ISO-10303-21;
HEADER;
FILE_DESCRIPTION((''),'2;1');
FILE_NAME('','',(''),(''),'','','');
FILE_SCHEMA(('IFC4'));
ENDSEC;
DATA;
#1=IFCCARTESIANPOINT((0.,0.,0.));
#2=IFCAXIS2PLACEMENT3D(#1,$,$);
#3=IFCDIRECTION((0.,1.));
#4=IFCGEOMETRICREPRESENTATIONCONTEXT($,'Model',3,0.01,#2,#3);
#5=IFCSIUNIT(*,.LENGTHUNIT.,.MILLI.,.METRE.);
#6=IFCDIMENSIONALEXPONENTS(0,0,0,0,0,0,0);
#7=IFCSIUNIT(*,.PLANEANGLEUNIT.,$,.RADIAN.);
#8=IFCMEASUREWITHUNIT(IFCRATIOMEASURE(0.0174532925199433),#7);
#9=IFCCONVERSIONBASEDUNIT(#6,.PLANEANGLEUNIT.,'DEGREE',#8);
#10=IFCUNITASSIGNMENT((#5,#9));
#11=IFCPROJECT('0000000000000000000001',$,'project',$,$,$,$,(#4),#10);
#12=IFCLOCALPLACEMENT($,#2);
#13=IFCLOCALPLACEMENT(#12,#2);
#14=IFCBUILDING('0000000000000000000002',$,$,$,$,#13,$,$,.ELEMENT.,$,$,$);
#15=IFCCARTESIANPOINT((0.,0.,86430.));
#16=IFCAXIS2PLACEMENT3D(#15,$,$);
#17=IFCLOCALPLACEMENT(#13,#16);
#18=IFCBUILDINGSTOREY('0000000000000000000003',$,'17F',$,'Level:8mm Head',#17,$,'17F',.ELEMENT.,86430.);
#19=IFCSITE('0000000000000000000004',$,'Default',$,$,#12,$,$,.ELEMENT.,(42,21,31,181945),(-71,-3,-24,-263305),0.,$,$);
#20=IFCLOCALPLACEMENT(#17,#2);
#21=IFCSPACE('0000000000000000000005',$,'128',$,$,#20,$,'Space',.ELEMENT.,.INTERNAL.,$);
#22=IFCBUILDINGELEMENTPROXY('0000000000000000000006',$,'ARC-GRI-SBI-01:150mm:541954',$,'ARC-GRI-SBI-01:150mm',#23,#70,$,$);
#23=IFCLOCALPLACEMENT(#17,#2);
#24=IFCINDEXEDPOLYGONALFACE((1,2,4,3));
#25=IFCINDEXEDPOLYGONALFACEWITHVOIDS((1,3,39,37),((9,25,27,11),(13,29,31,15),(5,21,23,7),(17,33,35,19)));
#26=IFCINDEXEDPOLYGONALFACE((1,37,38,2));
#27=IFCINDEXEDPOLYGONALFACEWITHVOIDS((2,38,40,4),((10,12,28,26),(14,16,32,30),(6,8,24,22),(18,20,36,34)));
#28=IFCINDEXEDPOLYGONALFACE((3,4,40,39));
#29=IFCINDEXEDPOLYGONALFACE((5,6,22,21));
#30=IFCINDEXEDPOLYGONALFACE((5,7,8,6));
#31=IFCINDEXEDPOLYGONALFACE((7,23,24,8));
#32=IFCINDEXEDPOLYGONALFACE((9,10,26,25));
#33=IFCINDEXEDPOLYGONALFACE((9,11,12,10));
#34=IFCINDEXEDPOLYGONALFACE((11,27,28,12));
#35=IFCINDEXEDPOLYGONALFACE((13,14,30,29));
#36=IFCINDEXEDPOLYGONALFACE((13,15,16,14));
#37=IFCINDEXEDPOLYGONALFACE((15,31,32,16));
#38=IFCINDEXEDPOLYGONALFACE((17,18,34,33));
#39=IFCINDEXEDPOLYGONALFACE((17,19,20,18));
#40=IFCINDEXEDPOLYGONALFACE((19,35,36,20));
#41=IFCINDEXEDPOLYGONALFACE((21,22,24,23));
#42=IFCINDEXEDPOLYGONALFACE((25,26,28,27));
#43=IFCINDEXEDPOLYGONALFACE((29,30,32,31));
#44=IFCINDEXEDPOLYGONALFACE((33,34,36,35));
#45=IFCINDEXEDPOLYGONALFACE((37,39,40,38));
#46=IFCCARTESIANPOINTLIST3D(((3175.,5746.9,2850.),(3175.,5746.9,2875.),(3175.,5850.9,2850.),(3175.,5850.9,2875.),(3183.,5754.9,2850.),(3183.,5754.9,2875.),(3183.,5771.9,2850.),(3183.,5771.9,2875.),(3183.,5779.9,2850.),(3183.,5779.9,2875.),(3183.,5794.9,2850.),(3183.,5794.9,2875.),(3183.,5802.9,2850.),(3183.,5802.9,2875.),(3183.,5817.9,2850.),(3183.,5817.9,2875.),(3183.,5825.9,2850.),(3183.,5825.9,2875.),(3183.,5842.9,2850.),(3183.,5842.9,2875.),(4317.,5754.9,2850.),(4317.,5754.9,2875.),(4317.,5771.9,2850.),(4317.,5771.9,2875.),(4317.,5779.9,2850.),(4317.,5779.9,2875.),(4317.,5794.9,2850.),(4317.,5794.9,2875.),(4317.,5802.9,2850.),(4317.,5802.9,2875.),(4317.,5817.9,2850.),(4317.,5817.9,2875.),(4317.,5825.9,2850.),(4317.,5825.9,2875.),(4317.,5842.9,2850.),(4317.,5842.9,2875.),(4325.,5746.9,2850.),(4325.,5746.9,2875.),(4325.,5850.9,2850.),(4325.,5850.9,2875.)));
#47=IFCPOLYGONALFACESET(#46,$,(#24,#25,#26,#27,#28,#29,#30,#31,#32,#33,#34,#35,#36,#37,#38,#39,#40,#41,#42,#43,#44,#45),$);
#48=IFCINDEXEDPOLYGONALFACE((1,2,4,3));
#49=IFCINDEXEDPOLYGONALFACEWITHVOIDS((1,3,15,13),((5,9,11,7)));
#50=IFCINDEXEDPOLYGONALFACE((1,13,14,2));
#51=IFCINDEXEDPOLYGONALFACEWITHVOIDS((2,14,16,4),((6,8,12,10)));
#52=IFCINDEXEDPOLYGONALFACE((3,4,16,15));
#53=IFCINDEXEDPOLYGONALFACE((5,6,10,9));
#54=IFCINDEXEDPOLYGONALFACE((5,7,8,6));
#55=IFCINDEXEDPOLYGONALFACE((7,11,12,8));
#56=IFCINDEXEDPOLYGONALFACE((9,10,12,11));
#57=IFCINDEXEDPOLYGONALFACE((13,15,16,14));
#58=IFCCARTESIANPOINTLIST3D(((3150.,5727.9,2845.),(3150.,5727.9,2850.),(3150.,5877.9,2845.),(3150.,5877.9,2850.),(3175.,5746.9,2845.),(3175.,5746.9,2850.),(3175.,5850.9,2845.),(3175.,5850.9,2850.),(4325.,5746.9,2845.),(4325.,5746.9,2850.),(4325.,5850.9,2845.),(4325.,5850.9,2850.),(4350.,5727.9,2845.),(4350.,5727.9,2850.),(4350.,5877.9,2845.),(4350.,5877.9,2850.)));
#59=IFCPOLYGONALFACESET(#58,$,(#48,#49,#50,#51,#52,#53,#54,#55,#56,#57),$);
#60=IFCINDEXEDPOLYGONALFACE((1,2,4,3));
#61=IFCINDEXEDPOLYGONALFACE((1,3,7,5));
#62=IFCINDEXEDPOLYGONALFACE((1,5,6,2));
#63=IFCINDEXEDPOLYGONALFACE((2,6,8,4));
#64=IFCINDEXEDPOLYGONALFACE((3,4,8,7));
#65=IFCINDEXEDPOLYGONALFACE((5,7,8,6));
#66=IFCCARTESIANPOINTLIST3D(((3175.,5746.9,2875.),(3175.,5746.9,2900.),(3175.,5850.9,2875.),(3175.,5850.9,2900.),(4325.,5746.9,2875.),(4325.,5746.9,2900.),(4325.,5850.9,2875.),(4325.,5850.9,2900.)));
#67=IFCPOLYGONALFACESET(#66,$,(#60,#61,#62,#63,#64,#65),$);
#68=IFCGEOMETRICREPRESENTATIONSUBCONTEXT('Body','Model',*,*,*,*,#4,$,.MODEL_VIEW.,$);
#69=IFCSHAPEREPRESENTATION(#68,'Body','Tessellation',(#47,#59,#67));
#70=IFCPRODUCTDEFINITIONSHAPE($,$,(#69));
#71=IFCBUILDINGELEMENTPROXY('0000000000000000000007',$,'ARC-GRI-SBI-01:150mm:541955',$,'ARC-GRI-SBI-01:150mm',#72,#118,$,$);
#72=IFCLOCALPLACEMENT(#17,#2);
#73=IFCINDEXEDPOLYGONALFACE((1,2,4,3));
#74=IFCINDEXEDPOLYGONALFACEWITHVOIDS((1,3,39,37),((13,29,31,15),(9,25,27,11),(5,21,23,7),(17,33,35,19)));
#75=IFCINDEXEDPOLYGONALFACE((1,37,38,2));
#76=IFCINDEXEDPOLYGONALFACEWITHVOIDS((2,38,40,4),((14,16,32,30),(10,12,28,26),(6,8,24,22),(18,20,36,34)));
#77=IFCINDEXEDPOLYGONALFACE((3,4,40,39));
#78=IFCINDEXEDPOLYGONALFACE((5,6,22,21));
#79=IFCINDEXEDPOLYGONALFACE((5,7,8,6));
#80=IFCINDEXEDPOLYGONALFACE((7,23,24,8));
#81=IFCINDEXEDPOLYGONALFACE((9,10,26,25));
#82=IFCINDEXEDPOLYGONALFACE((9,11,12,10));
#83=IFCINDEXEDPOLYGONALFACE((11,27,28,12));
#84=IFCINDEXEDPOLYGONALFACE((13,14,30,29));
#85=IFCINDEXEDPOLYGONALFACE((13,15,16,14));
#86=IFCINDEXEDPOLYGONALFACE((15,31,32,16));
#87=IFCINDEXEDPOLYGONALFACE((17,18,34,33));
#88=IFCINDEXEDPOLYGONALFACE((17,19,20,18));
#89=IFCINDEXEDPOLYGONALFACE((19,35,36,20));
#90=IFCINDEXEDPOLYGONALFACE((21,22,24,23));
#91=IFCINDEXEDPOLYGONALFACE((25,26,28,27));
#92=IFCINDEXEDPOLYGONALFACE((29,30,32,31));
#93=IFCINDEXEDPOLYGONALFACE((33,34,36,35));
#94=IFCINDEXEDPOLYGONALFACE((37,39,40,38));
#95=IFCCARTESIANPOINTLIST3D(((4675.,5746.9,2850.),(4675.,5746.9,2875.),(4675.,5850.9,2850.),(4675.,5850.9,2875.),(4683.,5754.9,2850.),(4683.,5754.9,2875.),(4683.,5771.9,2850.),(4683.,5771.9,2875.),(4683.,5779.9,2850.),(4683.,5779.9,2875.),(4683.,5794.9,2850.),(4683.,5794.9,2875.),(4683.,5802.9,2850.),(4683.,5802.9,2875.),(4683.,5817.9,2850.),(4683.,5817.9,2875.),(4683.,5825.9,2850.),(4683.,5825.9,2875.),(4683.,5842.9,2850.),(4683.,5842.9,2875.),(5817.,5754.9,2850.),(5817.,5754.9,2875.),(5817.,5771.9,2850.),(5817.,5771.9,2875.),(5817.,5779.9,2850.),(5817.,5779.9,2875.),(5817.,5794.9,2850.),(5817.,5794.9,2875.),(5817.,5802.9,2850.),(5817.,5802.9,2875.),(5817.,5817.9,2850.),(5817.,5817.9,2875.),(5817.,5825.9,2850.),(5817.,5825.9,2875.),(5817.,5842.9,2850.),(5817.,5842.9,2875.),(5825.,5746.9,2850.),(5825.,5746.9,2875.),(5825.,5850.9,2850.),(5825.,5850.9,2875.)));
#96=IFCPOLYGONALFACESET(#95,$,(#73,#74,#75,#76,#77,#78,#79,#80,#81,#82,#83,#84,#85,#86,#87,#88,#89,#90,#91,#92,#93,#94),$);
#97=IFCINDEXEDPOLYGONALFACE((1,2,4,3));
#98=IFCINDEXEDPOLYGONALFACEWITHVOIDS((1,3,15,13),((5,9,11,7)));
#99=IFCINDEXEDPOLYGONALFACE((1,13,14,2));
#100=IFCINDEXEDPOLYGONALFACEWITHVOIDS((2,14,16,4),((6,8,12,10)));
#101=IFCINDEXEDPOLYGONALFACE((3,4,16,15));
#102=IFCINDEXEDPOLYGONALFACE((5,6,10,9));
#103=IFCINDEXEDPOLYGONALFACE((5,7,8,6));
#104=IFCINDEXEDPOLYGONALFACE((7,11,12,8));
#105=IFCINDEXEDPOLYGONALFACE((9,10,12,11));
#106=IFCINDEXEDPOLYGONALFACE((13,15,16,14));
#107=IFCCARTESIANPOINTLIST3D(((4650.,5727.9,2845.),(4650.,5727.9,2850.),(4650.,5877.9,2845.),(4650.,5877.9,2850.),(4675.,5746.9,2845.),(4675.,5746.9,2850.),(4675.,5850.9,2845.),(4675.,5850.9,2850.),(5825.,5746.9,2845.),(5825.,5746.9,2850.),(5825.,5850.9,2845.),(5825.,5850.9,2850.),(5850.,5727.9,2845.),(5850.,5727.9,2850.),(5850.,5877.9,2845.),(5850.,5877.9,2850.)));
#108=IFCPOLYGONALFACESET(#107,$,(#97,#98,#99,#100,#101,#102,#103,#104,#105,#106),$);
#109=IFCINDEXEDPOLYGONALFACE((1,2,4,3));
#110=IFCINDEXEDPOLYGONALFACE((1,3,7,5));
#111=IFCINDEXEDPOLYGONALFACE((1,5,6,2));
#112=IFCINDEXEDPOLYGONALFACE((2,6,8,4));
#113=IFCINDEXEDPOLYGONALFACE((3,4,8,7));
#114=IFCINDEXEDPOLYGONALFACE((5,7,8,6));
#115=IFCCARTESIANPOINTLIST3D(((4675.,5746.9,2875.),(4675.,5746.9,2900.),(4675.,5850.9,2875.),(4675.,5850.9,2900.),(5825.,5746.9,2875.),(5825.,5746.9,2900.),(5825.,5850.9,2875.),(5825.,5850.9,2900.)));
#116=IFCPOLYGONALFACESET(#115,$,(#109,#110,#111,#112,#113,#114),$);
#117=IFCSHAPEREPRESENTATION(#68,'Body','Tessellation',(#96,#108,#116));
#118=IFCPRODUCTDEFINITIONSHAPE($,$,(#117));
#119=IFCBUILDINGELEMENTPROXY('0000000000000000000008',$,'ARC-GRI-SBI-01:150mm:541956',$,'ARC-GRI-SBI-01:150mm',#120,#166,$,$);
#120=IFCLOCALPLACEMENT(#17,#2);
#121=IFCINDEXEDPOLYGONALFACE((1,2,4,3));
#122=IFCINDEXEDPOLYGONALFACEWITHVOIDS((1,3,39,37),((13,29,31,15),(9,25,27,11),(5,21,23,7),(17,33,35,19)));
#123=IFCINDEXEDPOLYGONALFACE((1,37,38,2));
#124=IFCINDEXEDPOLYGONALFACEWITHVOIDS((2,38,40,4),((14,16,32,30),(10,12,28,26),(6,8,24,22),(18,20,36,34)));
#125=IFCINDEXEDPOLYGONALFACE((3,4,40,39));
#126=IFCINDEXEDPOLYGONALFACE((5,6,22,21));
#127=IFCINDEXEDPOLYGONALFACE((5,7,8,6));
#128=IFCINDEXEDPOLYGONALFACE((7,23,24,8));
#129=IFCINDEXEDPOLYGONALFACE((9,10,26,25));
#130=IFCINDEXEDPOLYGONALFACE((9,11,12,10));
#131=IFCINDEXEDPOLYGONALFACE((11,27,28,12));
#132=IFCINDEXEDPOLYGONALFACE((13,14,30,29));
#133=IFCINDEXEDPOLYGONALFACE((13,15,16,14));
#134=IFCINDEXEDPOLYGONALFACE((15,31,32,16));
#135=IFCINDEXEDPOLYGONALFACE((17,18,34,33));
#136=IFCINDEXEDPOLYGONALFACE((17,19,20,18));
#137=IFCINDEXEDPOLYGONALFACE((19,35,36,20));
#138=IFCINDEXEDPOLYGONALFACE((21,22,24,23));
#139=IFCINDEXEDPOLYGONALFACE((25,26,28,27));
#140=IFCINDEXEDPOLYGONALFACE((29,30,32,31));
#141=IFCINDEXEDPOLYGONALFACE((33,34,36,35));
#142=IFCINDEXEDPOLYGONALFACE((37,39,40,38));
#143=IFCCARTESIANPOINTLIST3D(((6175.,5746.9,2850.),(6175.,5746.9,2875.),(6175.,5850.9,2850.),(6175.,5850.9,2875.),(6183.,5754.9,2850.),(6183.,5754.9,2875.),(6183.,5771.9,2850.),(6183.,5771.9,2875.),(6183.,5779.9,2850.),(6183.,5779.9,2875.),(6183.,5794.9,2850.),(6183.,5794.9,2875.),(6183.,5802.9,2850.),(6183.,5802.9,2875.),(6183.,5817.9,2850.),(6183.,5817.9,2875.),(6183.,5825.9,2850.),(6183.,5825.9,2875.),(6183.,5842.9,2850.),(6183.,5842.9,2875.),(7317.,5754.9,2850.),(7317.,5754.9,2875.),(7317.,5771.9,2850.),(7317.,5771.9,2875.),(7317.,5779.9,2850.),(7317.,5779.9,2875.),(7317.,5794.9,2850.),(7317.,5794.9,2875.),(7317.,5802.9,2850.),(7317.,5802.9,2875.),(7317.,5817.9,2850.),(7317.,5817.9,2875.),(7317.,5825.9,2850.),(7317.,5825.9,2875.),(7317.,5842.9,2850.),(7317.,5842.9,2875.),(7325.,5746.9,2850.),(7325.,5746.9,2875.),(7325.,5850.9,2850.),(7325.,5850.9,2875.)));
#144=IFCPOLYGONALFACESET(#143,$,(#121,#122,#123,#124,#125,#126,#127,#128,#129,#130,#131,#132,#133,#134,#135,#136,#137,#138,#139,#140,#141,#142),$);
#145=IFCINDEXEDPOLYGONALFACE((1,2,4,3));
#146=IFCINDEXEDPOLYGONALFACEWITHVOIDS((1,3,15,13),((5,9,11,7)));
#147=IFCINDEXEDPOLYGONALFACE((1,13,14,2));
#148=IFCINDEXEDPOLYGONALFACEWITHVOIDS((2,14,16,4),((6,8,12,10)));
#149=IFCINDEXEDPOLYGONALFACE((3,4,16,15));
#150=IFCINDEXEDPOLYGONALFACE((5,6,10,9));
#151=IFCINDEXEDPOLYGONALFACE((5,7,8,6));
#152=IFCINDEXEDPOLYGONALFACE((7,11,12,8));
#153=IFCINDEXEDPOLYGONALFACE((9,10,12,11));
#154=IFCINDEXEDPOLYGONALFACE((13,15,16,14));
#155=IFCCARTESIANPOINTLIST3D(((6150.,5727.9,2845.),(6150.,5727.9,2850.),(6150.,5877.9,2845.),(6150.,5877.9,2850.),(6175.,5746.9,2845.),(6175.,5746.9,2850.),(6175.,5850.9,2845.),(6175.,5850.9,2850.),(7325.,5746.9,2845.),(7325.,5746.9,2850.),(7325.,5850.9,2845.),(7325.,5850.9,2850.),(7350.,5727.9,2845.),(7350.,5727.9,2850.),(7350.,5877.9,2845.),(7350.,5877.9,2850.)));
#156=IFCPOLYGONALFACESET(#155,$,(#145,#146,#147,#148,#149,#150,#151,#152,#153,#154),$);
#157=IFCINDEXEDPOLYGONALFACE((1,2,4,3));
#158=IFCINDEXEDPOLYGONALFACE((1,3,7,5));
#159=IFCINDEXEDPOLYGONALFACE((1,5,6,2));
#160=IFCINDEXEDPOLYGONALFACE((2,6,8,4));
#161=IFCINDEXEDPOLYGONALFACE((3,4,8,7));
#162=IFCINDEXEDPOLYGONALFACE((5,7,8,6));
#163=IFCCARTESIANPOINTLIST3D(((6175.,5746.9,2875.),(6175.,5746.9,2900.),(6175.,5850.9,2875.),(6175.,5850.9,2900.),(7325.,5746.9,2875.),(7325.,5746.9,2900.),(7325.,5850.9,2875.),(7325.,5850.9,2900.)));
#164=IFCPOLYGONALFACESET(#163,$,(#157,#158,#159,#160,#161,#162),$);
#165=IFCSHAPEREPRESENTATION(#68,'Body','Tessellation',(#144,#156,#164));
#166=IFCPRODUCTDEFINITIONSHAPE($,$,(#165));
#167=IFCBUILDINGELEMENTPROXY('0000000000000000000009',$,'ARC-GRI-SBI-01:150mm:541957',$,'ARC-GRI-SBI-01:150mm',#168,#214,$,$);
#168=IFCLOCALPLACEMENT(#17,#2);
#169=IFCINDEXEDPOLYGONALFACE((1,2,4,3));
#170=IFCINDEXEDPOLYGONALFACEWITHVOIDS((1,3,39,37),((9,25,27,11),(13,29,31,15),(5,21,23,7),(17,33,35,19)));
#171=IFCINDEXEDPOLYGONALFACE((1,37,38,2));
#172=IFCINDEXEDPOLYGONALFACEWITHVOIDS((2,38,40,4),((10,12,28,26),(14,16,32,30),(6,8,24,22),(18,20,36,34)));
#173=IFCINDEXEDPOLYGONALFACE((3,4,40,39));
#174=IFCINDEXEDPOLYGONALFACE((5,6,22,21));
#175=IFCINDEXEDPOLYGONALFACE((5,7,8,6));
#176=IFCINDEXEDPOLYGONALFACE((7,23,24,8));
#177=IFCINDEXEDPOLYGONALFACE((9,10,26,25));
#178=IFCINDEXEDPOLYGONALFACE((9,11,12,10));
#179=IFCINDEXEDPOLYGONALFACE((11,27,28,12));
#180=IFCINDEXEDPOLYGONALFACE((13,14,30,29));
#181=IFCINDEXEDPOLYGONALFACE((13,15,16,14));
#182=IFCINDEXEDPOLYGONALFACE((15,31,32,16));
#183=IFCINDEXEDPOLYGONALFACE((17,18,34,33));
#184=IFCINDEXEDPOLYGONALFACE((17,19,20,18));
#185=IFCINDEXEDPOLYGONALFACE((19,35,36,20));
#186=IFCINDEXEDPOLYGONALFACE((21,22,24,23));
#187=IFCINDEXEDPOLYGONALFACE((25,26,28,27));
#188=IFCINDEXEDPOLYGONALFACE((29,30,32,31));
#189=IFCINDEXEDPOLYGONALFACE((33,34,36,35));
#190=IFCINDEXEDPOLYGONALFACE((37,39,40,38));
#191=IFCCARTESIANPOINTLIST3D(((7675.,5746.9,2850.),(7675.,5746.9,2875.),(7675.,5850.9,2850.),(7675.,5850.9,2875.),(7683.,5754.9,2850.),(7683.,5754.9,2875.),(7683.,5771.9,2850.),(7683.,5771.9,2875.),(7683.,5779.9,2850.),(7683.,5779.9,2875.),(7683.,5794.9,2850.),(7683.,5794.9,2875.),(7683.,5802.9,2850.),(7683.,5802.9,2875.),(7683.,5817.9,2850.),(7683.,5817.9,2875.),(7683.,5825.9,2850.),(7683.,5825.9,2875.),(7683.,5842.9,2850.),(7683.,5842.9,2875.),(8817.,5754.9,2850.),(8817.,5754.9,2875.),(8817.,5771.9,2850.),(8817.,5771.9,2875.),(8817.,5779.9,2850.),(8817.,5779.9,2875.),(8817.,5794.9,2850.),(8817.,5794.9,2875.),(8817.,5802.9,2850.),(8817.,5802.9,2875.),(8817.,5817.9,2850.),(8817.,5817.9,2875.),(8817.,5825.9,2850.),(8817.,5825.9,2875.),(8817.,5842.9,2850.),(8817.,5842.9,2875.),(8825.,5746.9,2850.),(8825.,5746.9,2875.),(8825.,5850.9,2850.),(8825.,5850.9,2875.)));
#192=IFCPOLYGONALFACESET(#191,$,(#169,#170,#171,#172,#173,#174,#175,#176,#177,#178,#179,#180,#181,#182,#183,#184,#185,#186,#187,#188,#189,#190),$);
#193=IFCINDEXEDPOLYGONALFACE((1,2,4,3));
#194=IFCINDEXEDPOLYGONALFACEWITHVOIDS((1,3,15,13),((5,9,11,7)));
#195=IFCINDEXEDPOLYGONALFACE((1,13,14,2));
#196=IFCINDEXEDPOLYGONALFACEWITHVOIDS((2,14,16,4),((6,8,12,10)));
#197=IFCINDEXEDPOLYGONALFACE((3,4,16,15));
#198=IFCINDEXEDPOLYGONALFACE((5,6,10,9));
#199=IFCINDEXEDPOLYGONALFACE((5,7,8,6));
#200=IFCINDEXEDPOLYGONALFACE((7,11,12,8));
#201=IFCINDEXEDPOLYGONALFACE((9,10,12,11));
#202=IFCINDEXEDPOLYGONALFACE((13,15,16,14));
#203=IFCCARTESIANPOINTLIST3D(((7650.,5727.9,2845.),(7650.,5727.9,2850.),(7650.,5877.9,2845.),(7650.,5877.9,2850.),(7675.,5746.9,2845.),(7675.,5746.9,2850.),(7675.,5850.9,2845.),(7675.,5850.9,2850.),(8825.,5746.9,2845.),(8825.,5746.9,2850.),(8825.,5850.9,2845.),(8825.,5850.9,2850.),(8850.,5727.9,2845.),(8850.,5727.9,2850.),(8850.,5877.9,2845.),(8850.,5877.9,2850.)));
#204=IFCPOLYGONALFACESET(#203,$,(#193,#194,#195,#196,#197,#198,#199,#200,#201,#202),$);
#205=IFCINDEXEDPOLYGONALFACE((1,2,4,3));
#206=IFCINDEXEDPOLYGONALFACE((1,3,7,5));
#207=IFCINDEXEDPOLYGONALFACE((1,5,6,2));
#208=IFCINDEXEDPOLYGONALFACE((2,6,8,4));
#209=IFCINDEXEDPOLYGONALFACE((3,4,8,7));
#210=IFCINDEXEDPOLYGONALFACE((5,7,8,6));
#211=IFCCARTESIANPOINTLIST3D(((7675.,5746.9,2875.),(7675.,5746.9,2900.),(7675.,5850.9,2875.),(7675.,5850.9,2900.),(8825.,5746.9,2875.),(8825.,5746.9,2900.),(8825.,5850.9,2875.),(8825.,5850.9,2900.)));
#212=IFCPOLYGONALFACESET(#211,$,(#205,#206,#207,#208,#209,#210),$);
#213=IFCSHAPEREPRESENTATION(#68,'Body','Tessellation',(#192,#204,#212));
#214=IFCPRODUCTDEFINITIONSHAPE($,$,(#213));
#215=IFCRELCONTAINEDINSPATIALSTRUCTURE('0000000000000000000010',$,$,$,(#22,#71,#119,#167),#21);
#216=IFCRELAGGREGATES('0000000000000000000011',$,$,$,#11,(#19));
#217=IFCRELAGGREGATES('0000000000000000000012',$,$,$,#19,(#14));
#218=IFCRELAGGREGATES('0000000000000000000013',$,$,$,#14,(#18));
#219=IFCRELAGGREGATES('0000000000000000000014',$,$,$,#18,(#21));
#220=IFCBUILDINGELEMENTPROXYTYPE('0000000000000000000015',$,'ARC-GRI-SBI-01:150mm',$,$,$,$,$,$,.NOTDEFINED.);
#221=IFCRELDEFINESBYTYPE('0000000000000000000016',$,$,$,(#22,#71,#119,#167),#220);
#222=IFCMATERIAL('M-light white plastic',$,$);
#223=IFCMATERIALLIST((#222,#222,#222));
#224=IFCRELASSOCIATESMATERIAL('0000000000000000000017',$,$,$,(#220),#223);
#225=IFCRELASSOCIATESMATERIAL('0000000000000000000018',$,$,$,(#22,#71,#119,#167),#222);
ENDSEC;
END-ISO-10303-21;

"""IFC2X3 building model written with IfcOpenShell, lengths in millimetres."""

from ifc_helpers import new_model, entity, si_unit, converted_unit, direction, frame, origin, origin_2d_with_axis, place, context, subcontext, project, spatial, polyline, rectangle, outline, extrude, source, transform, mapped, material, material_list, type_object, type_shapes, element, save


model = new_model("IFC2X3")

# Units and contexts
model_context = context("Model", 3, precision=0.01, world=origin(), true_north=direction((0.0, 1.0)))
body_context = subcontext(model_context, "Body", "Model", "MODEL_VIEW")
ifc_project = project(units=[si_unit("LENGTHUNIT", "METRE", prefix="MILLI"), converted_unit("PLANEANGLEUNIT", "DEGREE", entity("IfcRatioMeasure", 0.0174532925199433), si_unit("PLANEANGLEUNIT", "RADIAN"), dimensions=[0, 0, 0, 0, 0, 0, 0])], contexts=[model_context])

# Site, building, storey
site_placement = place(None, origin())
site = spatial("IfcSite", under=ifc_project, at=site_placement, Name="Default", CompositionType="ELEMENT", RefLatitude=(42, 21, 31, 181945), RefLongitude=(-71, -3, -24, -263305), RefElevation=0.0)
building_placement = place(site_placement, origin())
building = spatial("IfcBuilding", under=site, at=building_placement, CompositionType="ELEMENT")
storey_placement = place(building_placement, frame((0.0, 0.0, 86430.0)))
storey = spatial("IfcBuildingStorey", under=building, at=storey_placement, Name="17F", ObjectType="Level:8mm Head", LongName="17F", CompositionType="ELEMENT", Elevation=86430.0)

# Shared definitions
space_placement = place(storey_placement, origin())
space = spatial("IfcSpace", under=storey, at=space_placement, Name="128", LongName="Space", CompositionType="ELEMENT", InteriorOrExteriorSpace="INTERNAL")

# Building element proxies
ifc_material_1 = material(Name="M-light white plastic")
ifc_material_list = material_list([ifc_material_1, ifc_material_1, ifc_material_1])
building_element_proxy_type = type_object("IfcBuildingElementProxyType", Name="ARC-GRI-SBI-01:150mm", PredefinedType="NOTDEFINED", material=ifc_material_list)
shared_shape = source(origin(), body_context, "Body", "SweptSolid", [
    extrude(outline(polyline([(-575.0, -52.0), (575.0, -52.0), (575.0, 52.0), (-575.0, 52.0), (-575.0, -52.0)]), holes=[polyline([(-567.0, -44.0), (-567.0, -27.0), (567.0, -27.0), (567.0, -44.0), (-567.0, -44.0)]), polyline([(567.0, -4.0), (567.0, -19.0), (-567.0, -19.0), (-567.0, -4.0), (567.0, -4.0)]), polyline([(-567.0, 44.0), (567.0, 44.0), (567.0, 27.0), (-567.0, 27.0), (-567.0, 44.0)]), polyline([(567.0, 4.0), (-567.0, 4.0), (-567.0, 19.0), (567.0, 19.0), (567.0, 4.0)])]), frame((425.0, 4.0, 4000.0), z_axis=(0.0, 0.0, 1.0), x_axis=(-1.0, 0.0, 0.0)), (0.0, 0.0, 1.0), 25.0),
    extrude(outline(polyline([(-600.0, -75.0), (600.0, -75.0), (600.0, 75.0), (-600.0, 75.0), (-600.0, -75.0)]), holes=[polyline([(-575.0, -56.0), (-575.0, 48.0), (575.0, 48.0), (575.0, -56.0), (-575.0, -56.0)])]), frame((425.0, 0.0, 3995.0), z_axis=(0.0, 0.0, 1.0), x_axis=(-1.0, 0.0, 0.0)), (0.0, 0.0, 1.0), 5.0),
    extrude(rectangle(XDim=1150.0, YDim=104.0, at=origin_2d_with_axis()), frame((425.0, 4.0, 4025.0), z_axis=(0.0, 0.0, 1.0), x_axis=(-1.0, 0.0, 0.0)), (0.0, 0.0, 1.0), 25.0),
])
type_shapes(building_element_proxy_type, [shared_shape])
for number, where, z_axis, x_axis, name in (
    (1, (4175.0, 5802.9, -1150.0), (0.0, 0.0, 1.0), (-1.0, 0.0, 0.0), "ARC-GRI-SBI-01:150mm:541954"),
    (2, (5675.0, 5802.9, -1150.0), (0.0, 0.0, 1.0), (-1.0, 0.0, 0.0), "ARC-GRI-SBI-01:150mm:541955"),
    (3, (7175.0, 5802.9, -1150.0), (0.0, 0.0, 1.0), (-1.0, 0.0, 0.0), "ARC-GRI-SBI-01:150mm:541956"),
    (4, (8675.0, 5802.9, -1150.0), (0.0, 0.0, 1.0), (-1.0, 0.0, 0.0), "ARC-GRI-SBI-01:150mm:541957"),
):
    element("IfcBuildingElementProxy", number, at=place(space_placement, frame(where, z_axis=z_axis, x_axis=x_axis)), inside=space, type_object=building_element_proxy_type, material=ifc_material_1, Name=name, ObjectType="ARC-GRI-SBI-01:150mm", context=body_context, shape_type="MappedRepresentation", body=[
        mapped(shared_shape, transform((0.0, 0.0, 0.0), scale=1.0)),
    ])

save(model, "model.ifc")
